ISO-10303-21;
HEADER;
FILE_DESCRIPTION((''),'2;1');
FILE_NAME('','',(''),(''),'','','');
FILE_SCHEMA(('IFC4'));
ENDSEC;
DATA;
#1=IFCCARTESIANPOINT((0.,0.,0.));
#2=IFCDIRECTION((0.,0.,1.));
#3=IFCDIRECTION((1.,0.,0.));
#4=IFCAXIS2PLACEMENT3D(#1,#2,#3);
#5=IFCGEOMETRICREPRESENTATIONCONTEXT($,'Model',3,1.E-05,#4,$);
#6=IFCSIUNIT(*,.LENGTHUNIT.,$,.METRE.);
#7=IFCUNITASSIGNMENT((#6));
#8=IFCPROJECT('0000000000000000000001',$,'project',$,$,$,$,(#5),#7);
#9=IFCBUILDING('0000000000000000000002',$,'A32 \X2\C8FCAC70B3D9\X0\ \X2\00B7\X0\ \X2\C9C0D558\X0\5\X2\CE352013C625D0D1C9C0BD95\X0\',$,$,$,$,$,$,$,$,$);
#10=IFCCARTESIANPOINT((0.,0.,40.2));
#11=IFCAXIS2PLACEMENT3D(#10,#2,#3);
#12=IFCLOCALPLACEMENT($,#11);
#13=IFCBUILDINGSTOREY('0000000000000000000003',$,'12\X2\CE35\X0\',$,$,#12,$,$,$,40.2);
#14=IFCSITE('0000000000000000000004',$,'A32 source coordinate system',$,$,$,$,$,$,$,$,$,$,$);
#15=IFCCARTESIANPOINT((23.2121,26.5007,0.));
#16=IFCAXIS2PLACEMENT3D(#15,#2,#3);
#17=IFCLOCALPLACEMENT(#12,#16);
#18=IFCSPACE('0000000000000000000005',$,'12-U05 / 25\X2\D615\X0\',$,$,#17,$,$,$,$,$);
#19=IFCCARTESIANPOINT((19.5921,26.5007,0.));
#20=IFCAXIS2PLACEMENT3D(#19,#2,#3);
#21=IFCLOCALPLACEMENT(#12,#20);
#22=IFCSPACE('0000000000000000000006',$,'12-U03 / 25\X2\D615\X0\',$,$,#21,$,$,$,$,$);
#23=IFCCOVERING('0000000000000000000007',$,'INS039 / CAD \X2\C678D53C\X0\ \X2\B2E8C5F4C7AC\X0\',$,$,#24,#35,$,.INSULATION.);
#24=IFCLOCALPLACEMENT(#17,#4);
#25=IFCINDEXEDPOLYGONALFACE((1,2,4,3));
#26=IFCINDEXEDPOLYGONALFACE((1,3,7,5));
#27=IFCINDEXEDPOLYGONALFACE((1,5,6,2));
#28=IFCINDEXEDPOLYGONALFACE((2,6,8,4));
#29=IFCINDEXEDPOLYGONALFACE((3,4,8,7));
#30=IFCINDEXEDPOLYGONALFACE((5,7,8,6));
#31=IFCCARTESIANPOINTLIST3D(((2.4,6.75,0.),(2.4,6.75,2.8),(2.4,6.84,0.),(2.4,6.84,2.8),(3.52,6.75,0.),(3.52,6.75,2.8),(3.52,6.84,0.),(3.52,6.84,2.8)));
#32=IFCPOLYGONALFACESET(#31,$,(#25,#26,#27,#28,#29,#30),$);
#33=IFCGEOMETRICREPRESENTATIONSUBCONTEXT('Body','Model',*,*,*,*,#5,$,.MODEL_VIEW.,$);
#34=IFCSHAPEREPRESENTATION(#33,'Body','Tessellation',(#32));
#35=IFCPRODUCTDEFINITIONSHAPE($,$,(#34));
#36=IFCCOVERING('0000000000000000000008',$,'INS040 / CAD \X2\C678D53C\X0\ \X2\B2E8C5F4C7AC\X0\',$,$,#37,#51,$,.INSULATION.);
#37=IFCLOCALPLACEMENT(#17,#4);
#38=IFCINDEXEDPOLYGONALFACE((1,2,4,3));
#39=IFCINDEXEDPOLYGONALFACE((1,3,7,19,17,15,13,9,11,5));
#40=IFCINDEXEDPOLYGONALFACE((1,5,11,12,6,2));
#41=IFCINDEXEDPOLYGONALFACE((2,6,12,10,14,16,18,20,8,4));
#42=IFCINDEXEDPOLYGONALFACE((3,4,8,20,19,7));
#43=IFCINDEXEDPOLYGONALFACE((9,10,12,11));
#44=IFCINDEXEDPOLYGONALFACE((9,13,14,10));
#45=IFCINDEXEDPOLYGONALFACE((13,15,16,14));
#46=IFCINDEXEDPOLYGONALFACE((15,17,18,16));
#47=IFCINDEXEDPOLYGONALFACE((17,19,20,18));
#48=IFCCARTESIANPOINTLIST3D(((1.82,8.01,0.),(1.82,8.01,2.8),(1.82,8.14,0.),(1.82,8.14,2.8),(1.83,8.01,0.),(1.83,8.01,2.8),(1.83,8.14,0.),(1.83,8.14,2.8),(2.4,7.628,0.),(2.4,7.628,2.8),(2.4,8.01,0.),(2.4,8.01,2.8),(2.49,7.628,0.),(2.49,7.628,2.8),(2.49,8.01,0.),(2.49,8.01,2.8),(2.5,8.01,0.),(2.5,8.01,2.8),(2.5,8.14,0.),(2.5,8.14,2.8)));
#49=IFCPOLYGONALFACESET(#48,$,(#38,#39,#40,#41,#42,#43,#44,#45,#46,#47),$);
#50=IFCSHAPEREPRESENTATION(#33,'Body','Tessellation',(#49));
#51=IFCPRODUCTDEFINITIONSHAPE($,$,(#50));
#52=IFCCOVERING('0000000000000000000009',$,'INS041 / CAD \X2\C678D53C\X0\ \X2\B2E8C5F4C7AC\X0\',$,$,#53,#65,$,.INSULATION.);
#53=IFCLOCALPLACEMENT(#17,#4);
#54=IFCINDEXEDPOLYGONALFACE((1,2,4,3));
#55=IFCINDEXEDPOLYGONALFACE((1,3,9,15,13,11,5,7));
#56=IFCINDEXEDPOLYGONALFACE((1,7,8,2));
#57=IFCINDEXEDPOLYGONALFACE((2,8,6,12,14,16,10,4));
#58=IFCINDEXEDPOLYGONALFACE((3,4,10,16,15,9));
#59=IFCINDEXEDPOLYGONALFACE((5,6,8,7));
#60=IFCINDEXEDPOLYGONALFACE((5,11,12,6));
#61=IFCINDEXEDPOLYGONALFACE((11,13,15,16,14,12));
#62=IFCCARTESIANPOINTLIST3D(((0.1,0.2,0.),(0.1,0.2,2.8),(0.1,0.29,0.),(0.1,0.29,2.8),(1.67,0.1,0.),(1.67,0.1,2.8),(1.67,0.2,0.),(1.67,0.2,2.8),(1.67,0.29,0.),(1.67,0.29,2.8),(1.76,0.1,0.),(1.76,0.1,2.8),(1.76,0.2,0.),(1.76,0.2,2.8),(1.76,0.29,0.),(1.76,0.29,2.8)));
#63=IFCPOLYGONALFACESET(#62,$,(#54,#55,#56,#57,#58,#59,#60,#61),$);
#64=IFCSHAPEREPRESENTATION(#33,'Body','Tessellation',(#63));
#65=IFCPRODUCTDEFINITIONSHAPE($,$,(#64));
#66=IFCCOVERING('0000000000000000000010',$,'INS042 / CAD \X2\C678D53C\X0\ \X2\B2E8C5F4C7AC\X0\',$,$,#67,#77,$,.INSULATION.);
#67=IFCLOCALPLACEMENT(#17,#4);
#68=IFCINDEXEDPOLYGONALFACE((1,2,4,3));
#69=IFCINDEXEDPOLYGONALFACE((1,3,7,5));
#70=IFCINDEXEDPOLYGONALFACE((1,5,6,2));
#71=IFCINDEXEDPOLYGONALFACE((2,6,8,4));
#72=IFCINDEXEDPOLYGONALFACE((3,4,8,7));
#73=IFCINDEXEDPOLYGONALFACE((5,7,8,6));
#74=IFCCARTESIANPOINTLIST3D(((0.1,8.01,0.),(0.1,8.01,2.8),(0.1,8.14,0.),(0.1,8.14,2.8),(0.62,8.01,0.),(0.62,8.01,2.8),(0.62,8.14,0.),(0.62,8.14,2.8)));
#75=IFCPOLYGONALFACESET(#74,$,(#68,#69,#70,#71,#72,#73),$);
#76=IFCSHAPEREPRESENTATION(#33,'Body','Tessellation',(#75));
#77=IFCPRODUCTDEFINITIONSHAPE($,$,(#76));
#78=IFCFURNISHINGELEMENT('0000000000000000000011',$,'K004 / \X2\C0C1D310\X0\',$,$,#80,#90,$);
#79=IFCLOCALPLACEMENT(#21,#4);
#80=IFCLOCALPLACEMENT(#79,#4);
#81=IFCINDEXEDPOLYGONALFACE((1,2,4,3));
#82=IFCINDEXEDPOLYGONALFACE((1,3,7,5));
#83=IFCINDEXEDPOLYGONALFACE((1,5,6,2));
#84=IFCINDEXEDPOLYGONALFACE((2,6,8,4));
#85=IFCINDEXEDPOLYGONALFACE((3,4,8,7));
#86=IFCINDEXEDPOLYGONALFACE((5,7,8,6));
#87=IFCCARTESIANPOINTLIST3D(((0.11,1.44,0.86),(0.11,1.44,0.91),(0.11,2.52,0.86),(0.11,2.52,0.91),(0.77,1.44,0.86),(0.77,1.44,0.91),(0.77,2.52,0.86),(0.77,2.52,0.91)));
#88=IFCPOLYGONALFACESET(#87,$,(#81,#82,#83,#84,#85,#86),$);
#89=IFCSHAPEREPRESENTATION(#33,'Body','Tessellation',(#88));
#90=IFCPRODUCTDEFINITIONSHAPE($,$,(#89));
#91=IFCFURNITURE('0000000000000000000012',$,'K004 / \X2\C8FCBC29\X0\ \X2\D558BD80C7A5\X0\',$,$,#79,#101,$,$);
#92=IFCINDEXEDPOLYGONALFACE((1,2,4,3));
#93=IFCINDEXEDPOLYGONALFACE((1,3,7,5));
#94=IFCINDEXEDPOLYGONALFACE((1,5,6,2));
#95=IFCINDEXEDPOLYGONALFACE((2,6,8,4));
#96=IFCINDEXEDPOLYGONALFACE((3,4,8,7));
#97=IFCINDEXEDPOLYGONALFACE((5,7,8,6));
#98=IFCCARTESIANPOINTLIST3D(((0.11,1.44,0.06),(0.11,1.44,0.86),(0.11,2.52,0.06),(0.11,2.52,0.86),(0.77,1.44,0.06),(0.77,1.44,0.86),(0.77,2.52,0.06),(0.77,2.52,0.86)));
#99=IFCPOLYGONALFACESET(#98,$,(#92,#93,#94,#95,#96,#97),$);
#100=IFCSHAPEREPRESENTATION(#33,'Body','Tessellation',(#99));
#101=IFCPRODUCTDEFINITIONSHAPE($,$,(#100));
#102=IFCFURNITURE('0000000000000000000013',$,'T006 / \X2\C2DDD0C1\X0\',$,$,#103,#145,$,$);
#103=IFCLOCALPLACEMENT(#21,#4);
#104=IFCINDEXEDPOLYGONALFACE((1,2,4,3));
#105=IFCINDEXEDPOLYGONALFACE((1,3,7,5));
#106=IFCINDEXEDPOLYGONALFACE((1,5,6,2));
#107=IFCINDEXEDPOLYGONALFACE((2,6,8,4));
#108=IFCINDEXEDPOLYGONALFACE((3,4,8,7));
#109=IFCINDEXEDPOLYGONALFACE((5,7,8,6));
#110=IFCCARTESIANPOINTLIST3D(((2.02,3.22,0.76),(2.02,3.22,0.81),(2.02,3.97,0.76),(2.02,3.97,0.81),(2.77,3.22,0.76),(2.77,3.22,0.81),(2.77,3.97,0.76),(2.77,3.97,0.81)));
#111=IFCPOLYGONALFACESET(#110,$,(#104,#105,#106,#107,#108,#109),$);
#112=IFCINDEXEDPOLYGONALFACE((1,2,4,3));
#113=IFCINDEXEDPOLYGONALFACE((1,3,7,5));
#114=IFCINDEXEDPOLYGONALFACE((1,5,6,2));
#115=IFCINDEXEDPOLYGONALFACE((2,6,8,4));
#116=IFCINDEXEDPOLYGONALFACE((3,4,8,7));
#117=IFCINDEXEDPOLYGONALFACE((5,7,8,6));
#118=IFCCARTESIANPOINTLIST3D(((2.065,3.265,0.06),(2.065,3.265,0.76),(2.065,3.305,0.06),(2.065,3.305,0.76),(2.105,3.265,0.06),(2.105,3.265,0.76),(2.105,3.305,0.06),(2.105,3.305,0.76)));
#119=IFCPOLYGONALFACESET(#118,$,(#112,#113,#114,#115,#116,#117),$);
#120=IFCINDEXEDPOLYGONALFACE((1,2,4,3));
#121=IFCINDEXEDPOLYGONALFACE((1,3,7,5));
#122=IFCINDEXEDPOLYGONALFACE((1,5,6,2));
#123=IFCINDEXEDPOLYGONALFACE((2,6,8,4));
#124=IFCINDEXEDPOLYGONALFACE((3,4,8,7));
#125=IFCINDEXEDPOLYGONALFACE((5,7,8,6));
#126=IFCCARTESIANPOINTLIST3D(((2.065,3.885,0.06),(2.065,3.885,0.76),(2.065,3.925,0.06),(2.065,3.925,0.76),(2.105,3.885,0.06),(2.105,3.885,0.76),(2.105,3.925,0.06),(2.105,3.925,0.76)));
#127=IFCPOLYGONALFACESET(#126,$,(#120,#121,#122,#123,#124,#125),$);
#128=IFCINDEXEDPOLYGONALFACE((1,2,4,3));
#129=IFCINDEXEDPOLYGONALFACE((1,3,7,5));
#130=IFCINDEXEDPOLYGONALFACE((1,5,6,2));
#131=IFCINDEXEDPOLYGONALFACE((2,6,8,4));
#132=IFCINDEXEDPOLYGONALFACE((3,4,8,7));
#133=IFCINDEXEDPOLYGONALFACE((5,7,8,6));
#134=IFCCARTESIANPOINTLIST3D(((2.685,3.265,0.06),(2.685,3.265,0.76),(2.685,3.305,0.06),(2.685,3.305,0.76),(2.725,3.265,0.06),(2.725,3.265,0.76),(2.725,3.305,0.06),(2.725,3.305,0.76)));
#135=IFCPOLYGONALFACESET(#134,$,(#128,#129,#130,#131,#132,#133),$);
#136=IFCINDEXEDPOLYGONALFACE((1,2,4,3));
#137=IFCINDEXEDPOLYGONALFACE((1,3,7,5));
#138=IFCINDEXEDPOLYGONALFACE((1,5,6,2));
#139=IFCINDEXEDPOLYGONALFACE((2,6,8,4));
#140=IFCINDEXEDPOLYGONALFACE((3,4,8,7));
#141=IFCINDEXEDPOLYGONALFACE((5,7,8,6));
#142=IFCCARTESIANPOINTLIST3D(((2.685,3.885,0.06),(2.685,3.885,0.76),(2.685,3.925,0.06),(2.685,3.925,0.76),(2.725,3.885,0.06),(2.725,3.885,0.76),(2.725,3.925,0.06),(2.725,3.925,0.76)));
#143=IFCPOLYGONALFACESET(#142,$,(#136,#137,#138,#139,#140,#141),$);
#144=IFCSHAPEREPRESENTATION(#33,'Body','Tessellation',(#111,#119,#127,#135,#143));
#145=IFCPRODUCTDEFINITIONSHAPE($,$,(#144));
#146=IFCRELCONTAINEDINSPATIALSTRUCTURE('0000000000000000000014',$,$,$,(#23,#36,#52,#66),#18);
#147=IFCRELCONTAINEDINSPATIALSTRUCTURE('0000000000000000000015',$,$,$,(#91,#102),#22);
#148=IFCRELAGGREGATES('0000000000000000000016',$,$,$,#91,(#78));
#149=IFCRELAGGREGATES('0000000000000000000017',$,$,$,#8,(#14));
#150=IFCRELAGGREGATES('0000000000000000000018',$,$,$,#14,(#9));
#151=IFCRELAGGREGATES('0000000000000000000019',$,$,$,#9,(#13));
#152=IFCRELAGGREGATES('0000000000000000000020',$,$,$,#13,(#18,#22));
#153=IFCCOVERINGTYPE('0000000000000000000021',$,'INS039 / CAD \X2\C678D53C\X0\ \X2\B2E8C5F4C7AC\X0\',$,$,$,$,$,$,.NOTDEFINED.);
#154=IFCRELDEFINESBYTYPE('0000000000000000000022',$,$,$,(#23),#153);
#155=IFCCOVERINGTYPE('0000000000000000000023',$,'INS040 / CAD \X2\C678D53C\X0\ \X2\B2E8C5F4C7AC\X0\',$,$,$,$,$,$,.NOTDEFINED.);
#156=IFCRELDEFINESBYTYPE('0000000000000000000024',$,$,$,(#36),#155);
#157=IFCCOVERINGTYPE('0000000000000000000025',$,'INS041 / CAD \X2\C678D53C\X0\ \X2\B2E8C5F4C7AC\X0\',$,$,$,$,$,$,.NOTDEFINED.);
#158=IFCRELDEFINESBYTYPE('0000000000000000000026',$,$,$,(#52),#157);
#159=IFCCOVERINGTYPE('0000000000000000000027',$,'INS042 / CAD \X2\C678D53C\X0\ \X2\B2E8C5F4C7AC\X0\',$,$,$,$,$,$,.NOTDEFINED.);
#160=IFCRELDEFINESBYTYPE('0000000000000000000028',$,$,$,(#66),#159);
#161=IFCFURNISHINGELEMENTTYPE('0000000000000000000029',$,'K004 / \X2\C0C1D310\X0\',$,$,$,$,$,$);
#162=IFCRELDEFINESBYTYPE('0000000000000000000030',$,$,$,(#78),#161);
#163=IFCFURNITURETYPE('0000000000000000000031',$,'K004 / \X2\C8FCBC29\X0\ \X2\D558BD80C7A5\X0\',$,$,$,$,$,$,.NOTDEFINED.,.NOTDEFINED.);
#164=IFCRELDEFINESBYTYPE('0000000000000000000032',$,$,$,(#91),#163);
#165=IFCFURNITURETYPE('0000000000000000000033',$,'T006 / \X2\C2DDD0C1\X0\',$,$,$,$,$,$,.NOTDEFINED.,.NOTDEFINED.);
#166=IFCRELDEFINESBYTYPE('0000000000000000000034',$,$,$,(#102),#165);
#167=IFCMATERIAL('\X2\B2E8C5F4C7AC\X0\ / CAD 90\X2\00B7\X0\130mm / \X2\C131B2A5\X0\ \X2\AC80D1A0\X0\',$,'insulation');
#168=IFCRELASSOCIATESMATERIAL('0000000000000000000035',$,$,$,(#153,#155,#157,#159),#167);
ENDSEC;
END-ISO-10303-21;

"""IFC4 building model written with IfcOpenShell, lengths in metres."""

from ifc_helpers import new_model, si_unit, frame, origin, origin_with_axes, place, context, subcontext, project, spatial, polyline, outline, extrude, source, transform, mapped, material, type_object, type_shapes, element, aggregate, save


model = new_model("IFC4")

# Units and contexts
model_context = context("Model", 3, precision=1e-05, world=origin_with_axes())
body_context = subcontext(model_context, "Body", "Model", "MODEL_VIEW")
ifc_project = project(units=[si_unit("LENGTHUNIT", "METRE")], contexts=[model_context])

# Site, building, storey, space
storey_placement = place(None, frame((0.0, 0.0, 40.2), z_axis=(0.0, 0.0, 1.0), x_axis=(1.0, 0.0, 0.0)))
space_1_placement = place(storey_placement, frame((23.2121, 26.5007, 0.0), z_axis=(0.0, 0.0, 1.0), x_axis=(1.0, 0.0, 0.0)))
site = spatial("IfcSite", under=ifc_project, Name="A32 source coordinate system")
building = spatial("IfcBuilding", under=site, Name="A32 주거동 · 지하5층–옥탑지붕")
storey = spatial("IfcBuildingStorey", under=building, at=storey_placement, Name="12층", Elevation=40.2)
space_1 = spatial("IfcSpace", under=storey, at=space_1_placement, Name="12-U05 / 25형")

# Shared definitions
space_2_placement = place(storey_placement, frame((19.5921, 26.5007, 0.0), z_axis=(0.0, 0.0, 1.0), x_axis=(1.0, 0.0, 0.0)))
space_2 = spatial("IfcSpace", under=storey, at=space_2_placement, Name="12-U03 / 25형")

# Coverings
ifc_material = material(Name="단열재 / CAD 90·130mm / 성능 검토", Category="insulation")
covering_type_1 = type_object("IfcCoveringType", Name="INS039 / CAD 외피 단열재", PredefinedType="NOTDEFINED", material=ifc_material)
shared_shape_1 = source(origin(), body_context, "Body", "SweptSolid", [
    extrude(outline(polyline([(2.4, 6.75), (2.4, 6.84), (3.52, 6.84), (3.52, 6.75), (2.4, 6.75)])), origin(), (0.0, 0.0, 1.0), 2.8),
])
type_shapes(covering_type_1, [shared_shape_1])
covering_1_placement = place(space_1_placement, origin_with_axes())
element("IfcCovering", 1, at=covering_1_placement, inside=space_1, type_object=covering_type_1, Name="INS039 / CAD 외피 단열재", PredefinedType="INSULATION", context=body_context, shape_type="MappedRepresentation", body=[
    mapped(shared_shape_1, transform((0.0, 0.0, 0.0), scale=1.0)),
])
covering_type_2 = type_object("IfcCoveringType", Name="INS040 / CAD 외피 단열재", PredefinedType="NOTDEFINED", material=ifc_material)
shared_shape_2 = source(origin(), body_context, "Body", "SweptSolid", [
    extrude(outline(polyline([(2.4, 7.628), (2.4, 8.01), (1.83, 8.01), (1.82, 8.01), (1.82, 8.14), (1.83, 8.14), (2.5, 8.14), (2.5, 8.01), (2.49, 8.01), (2.49, 7.628), (2.4, 7.628)])), origin(), (0.0, 0.0, 1.0), 2.8),
])
type_shapes(covering_type_2, [shared_shape_2])
covering_2_placement = place(space_1_placement, origin_with_axes())
element("IfcCovering", 2, at=covering_2_placement, inside=space_1, type_object=covering_type_2, Name="INS040 / CAD 외피 단열재", PredefinedType="INSULATION", context=body_context, shape_type="MappedRepresentation", body=[
    mapped(shared_shape_2, transform((0.0, 0.0, 0.0), scale=1.0)),
])
covering_type_3 = type_object("IfcCoveringType", Name="INS041 / CAD 외피 단열재", PredefinedType="NOTDEFINED", material=ifc_material)
shared_shape_3 = source(origin(), body_context, "Body", "SweptSolid", [
    extrude(outline(polyline([(1.67, 0.2), (0.1, 0.2), (0.1, 0.29), (1.67, 0.29), (1.76, 0.29), (1.76, 0.2), (1.76, 0.1), (1.67, 0.1), (1.67, 0.2)])), origin(), (0.0, 0.0, 1.0), 2.8),
])
type_shapes(covering_type_3, [shared_shape_3])
covering_3_placement = place(space_1_placement, origin_with_axes())
element("IfcCovering", 3, at=covering_3_placement, inside=space_1, type_object=covering_type_3, Name="INS041 / CAD 외피 단열재", PredefinedType="INSULATION", context=body_context, shape_type="MappedRepresentation", body=[
    mapped(shared_shape_3, transform((0.0, 0.0, 0.0), scale=1.0)),
])
covering_type_4 = type_object("IfcCoveringType", Name="INS042 / CAD 외피 단열재", PredefinedType="NOTDEFINED", material=ifc_material)
shared_shape_4 = source(origin(), body_context, "Body", "SweptSolid", [
    extrude(outline(polyline([(0.62, 8.14), (0.62, 8.01), (0.1, 8.01), (0.1, 8.14), (0.62, 8.14)])), origin(), (0.0, 0.0, 1.0), 2.8),
])
type_shapes(covering_type_4, [shared_shape_4])
covering_4_placement = place(space_1_placement, origin_with_axes())
element("IfcCovering", 4, at=covering_4_placement, inside=space_1, type_object=covering_type_4, Name="INS042 / CAD 외피 단열재", PredefinedType="INSULATION", context=body_context, shape_type="MappedRepresentation", body=[
    mapped(shared_shape_4, transform((0.0, 0.0, 0.0), scale=1.0)),
])

# Furnishing element
furnishing_element_type_1 = type_object("IfcFurnishingElementType", Name="K004 / 상판")
shared_shape_5 = source(origin(), body_context, "Body", "SweptSolid", [
    extrude(outline(polyline([(0.77, 2.52), (0.77, 1.44), (0.11, 1.44), (0.11, 2.52), (0.77, 2.52)])), frame((0.0, 0.0, 0.86)), (0.0, 0.0, 1.0), 0.05),
])
type_shapes(furnishing_element_type_1, [shared_shape_5])
furniture_1_placement = place(space_2_placement, origin_with_axes())
furnishing_1_placement = place(furniture_1_placement, origin_with_axes())
furnishing_1 = element("IfcFurnishingElement", 5, at=furnishing_1_placement, type_object=furnishing_element_type_1, Name="K004 / 상판", context=body_context, shape_type="MappedRepresentation", body=[
    mapped(shared_shape_5, transform((0.0, 0.0, 0.0), scale=1.0)),
])

# Furniture
furniture_type_1 = type_object("IfcFurnitureType", Name="K004 / 주방 하부장", AssemblyPlace="NOTDEFINED", PredefinedType="NOTDEFINED")
shared_shape_6 = source(origin(), body_context, "Body", "SweptSolid", [
    extrude(outline(polyline([(0.11, 2.52), (0.77, 2.52), (0.77, 1.44), (0.11, 1.44), (0.11, 2.52)])), frame((0.0, 0.0, 0.06)), (0.0, 0.0, 1.0), 0.8),
])
type_shapes(furniture_type_1, [shared_shape_6])
furniture_1 = element("IfcFurniture", 6, at=furniture_1_placement, inside=space_2, type_object=furniture_type_1, Name="K004 / 주방 하부장", context=body_context, shape_type="MappedRepresentation", body=[
    mapped(shared_shape_6, transform((0.0, 0.0, 0.0), scale=1.0)),
])
aggregate(furniture_1, [furnishing_1])
furniture_type_2 = type_object("IfcFurnitureType", Name="T006 / 식탁", AssemblyPlace="NOTDEFINED", PredefinedType="NOTDEFINED")
shared_shape_7 = source(origin(), body_context, "Body", "SweptSolid", [
    extrude(outline(polyline([(2.77, 3.22), (2.02, 3.22), (2.02, 3.97), (2.77, 3.97), (2.77, 3.22)])), frame((0.0, 0.0, 0.76)), (0.0, 0.0, 1.0), 0.05),
    extrude(outline(polyline([(2.065, 3.265), (2.065, 3.305), (2.105, 3.305), (2.105, 3.265), (2.065, 3.265)])), frame((0.0, 0.0, 0.06)), (0.0, 0.0, 1.0), 0.7),
    extrude(outline(polyline([(2.065, 3.885), (2.065, 3.925), (2.105, 3.925), (2.105, 3.885), (2.065, 3.885)])), frame((0.0, 0.0, 0.06)), (0.0, 0.0, 1.0), 0.7),
    extrude(outline(polyline([(2.685, 3.265), (2.685, 3.305), (2.725, 3.305), (2.725, 3.265), (2.685, 3.265)])), frame((0.0, 0.0, 0.06)), (0.0, 0.0, 1.0), 0.7),
    extrude(outline(polyline([(2.685, 3.885), (2.685, 3.925), (2.725, 3.925), (2.725, 3.885), (2.685, 3.885)])), frame((0.0, 0.0, 0.06)), (0.0, 0.0, 1.0), 0.7),
])
type_shapes(furniture_type_2, [shared_shape_7])
furniture_2_placement = place(space_2_placement, origin_with_axes())
element("IfcFurniture", 7, at=furniture_2_placement, inside=space_2, type_object=furniture_type_2, Name="T006 / 식탁", context=body_context, shape_type="MappedRepresentation", body=[
    mapped(shared_shape_7, transform((0.0, 0.0, 0.0), scale=1.0)),
])

save(model, "model.ifc")
